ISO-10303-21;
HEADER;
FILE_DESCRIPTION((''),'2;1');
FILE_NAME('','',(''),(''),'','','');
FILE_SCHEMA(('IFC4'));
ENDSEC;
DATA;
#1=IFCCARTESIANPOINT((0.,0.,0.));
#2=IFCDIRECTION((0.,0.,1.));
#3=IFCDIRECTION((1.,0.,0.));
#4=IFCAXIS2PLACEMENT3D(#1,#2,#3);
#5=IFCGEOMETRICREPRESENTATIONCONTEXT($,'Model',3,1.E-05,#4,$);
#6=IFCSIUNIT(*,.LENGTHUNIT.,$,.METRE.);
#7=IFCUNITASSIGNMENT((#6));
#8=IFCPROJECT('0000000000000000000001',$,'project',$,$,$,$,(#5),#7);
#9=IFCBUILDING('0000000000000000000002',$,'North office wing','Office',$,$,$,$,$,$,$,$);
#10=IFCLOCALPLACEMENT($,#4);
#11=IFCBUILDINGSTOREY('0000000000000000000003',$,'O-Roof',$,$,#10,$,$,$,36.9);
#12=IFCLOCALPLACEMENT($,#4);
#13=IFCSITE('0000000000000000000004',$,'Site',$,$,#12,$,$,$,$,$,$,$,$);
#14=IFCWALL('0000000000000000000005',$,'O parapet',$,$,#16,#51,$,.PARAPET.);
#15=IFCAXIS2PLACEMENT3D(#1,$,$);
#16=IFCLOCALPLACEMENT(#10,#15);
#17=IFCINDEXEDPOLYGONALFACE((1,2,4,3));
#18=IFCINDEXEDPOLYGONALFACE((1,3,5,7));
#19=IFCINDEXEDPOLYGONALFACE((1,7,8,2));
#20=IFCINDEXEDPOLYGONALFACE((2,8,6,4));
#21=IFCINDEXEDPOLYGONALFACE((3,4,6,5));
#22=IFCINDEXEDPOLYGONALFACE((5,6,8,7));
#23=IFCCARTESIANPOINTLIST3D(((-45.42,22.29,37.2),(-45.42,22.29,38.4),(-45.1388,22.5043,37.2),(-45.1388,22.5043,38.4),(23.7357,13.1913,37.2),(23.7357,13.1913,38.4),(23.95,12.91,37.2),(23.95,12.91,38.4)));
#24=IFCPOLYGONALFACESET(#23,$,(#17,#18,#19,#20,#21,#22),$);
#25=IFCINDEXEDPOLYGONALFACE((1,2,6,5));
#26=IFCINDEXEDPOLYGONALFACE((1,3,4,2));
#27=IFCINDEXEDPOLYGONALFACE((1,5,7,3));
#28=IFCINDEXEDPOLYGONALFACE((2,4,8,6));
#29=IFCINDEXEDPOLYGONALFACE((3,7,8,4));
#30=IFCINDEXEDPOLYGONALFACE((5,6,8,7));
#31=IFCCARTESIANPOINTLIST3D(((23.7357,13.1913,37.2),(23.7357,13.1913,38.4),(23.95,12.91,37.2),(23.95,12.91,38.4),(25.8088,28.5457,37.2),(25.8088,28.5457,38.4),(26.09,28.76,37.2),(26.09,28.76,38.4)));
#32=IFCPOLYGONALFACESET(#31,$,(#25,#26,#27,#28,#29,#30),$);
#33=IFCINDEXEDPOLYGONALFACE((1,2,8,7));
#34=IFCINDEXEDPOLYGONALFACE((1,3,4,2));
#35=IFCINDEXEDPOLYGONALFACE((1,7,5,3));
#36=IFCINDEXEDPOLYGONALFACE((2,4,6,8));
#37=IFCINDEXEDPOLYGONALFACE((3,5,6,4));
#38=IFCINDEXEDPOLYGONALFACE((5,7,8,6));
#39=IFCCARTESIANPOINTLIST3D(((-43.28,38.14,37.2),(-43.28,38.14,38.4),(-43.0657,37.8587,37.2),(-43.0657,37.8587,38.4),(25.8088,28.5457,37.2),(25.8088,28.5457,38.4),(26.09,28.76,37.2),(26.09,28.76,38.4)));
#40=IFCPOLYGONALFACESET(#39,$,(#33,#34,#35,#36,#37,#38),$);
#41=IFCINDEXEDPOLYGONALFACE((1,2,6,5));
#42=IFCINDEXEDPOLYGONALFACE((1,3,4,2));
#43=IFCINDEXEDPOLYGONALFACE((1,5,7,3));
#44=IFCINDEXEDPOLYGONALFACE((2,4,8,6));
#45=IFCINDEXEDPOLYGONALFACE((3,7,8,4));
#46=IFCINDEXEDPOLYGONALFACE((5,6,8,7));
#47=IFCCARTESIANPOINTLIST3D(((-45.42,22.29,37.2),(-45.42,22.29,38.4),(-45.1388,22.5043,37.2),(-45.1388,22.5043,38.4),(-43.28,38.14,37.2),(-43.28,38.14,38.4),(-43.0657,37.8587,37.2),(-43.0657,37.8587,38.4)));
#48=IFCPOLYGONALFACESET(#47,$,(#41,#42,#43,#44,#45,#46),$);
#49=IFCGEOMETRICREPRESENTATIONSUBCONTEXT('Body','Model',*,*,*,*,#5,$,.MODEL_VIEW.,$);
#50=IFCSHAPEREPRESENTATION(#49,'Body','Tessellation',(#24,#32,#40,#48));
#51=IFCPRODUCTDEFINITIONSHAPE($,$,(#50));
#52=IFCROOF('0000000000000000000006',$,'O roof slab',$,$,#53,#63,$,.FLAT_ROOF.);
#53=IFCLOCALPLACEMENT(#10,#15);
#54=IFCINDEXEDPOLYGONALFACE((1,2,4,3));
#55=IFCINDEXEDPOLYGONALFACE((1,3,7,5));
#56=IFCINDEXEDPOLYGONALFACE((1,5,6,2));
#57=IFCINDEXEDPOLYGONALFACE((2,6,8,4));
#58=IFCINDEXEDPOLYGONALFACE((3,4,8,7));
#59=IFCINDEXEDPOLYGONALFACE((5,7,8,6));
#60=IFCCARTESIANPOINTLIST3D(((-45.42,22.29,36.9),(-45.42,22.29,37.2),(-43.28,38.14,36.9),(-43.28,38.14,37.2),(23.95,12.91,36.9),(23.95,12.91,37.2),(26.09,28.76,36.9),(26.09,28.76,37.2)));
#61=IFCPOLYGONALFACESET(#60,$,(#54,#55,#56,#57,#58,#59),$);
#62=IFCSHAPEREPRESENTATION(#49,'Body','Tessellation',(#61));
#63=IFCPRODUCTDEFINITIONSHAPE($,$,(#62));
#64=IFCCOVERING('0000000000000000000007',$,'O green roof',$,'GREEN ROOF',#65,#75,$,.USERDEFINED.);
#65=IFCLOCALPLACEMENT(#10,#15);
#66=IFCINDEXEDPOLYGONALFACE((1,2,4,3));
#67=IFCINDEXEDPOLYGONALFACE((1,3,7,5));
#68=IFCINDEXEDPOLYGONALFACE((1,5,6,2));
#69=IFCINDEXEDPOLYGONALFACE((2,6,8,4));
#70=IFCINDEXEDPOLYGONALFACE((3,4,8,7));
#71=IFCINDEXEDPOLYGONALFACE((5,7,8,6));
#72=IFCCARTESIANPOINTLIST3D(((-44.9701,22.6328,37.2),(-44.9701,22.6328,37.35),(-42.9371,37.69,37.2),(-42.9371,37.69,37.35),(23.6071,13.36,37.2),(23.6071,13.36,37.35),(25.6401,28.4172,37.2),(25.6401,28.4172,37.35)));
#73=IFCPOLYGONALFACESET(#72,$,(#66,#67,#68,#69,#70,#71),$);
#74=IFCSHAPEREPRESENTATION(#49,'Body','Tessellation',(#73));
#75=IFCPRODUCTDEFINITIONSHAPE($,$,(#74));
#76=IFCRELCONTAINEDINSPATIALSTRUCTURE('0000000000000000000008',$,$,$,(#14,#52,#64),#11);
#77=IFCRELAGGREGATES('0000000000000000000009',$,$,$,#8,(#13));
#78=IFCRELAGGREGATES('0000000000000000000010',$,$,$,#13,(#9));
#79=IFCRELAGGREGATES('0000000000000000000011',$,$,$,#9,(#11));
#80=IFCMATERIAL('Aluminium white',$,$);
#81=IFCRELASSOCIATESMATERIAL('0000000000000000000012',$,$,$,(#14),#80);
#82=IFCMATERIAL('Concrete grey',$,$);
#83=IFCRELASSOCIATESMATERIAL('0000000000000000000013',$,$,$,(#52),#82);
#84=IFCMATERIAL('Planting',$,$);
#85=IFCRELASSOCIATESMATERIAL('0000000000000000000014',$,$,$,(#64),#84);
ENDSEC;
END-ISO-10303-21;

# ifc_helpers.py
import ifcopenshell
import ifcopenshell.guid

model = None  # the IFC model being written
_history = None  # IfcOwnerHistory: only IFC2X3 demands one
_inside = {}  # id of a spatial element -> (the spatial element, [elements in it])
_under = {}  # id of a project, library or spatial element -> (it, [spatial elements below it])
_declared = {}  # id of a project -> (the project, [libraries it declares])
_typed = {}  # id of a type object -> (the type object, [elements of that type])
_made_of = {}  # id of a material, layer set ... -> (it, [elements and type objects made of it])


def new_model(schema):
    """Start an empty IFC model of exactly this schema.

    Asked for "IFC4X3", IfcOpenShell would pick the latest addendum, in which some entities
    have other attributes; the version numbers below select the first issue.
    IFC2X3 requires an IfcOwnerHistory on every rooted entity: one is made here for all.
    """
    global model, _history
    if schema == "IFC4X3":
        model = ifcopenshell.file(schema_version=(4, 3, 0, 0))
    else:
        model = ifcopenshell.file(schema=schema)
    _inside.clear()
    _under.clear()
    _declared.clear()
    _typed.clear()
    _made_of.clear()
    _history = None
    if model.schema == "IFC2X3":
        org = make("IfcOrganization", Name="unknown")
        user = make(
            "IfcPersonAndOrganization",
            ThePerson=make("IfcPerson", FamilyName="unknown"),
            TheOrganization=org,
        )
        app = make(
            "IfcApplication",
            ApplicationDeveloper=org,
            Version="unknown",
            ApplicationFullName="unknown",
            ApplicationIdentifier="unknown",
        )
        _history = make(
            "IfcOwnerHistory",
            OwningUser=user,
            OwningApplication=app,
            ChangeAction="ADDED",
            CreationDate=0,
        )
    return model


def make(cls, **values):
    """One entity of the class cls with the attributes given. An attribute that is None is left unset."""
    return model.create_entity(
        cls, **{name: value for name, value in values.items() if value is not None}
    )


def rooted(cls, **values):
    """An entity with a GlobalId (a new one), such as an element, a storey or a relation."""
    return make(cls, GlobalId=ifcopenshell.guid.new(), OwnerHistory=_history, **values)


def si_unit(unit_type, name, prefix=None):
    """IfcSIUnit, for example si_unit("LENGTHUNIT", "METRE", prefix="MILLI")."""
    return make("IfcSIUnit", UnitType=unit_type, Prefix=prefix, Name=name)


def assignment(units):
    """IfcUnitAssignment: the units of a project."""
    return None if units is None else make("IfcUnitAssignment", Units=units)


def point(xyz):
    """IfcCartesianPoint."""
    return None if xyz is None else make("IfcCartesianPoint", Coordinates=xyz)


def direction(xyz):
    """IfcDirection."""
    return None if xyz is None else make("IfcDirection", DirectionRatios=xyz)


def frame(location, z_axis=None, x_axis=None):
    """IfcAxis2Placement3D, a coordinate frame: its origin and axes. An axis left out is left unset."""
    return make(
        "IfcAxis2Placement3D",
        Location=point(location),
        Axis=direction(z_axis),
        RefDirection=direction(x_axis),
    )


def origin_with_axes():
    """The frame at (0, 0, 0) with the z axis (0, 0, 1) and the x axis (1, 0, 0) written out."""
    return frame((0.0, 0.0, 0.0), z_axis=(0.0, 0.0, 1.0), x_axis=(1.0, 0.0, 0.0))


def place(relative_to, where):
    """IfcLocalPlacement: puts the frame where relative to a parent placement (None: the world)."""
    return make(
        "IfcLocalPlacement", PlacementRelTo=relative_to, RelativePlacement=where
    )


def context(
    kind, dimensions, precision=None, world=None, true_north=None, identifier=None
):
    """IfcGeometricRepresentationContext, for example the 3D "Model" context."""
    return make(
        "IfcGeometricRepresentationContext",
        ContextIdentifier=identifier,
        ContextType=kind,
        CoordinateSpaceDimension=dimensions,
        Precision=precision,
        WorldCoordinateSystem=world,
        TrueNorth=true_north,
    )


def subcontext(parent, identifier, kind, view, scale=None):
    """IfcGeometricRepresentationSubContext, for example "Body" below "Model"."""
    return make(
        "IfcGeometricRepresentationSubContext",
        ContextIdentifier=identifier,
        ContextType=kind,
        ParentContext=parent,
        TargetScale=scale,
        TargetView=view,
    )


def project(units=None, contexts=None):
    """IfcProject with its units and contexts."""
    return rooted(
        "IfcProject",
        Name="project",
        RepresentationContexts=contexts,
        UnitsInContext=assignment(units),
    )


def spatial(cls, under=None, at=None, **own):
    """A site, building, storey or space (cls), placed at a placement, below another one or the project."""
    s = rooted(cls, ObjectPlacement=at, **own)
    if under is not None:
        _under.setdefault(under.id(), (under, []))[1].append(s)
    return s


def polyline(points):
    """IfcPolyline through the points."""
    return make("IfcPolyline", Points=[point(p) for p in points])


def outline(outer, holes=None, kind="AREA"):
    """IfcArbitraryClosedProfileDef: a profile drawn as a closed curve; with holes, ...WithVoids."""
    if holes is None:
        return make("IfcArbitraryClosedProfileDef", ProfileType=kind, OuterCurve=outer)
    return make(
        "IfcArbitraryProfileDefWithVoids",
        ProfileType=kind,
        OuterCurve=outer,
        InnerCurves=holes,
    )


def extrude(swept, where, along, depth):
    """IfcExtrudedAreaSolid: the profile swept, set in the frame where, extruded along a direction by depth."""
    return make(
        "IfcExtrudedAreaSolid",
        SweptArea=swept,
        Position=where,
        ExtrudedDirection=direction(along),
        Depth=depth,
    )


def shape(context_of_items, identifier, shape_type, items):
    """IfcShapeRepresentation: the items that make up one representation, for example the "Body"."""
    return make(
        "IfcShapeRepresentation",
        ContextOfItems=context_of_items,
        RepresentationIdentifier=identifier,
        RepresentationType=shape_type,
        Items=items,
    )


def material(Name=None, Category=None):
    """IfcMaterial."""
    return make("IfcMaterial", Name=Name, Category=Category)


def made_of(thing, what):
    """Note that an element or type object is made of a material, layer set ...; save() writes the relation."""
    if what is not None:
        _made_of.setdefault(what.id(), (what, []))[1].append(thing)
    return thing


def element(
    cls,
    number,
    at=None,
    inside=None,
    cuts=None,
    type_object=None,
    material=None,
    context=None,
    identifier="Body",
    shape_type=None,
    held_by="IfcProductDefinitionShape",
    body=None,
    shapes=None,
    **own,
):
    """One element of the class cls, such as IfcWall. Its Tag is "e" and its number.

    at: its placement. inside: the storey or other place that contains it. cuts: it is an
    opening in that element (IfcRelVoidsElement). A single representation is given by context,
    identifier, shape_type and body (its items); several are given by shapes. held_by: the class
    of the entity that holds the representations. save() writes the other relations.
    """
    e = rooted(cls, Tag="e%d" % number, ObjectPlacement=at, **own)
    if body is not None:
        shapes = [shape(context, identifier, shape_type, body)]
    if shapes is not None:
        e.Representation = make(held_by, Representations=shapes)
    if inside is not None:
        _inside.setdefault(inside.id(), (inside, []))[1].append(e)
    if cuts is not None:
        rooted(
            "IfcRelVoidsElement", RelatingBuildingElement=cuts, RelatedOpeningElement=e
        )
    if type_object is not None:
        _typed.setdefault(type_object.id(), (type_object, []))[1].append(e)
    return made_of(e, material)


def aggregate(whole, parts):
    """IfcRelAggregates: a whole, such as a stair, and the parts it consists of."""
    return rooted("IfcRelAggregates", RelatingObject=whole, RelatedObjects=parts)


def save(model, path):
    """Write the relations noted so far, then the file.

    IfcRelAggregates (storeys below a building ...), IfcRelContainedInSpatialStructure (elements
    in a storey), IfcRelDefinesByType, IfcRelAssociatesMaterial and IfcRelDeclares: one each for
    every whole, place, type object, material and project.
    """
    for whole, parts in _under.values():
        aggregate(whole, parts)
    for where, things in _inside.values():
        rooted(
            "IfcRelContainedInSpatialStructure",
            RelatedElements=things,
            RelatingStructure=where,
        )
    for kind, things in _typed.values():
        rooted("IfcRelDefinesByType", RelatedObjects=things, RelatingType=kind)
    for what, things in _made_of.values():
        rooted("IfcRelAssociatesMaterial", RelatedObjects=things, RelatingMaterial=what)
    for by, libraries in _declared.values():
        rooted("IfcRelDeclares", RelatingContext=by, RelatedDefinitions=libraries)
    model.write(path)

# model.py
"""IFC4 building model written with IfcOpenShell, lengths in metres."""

from ifc_helpers import new_model, si_unit, frame, origin_with_axes, place, context, subcontext, project, spatial, polyline, outline, extrude, material, element, save


model = new_model("IFC4")

# Units and contexts
model_context = context("Model", 3, precision=1e-05, world=origin_with_axes())
body_context = subcontext(model_context, "Body", "Model", "MODEL_VIEW")
ifc_project = project(units=[si_unit("LENGTHUNIT", "METRE")], contexts=[model_context])

# Site, building, storey
site_placement = place(None, origin_with_axes())
site = spatial("IfcSite", under=ifc_project, at=site_placement, Name="Site")
building = spatial("IfcBuilding", under=site, Name="North office wing", Description="Office")
storey_placement = place(None, origin_with_axes())
storey = spatial("IfcBuildingStorey", under=building, at=storey_placement, Name="O-Roof", Elevation=36.9)

# Wall
ifc_material_1 = material(Name="Aluminium white")
wall_placement = place(storey_placement, origin_with_axes())
element("IfcWall", 1, at=wall_placement, inside=storey, material=ifc_material_1, Name="O parapet", PredefinedType="PARAPET", context=body_context, shape_type="SweptSolid", body=[
    extrude(outline(polyline([(-45.42, 22.29), (23.95, 12.91), (23.7357, 13.1913), (-45.1388, 22.5043), (-45.42, 22.29)])), frame((0.0, 0.0, 37.2), z_axis=(0.0, 0.0, 1.0), x_axis=(1.0, 0.0, 0.0)), (0.0, 0.0, 1.0), 1.2),
    extrude(outline(polyline([(23.95, 12.91), (26.09, 28.76), (25.8088, 28.5457), (23.7357, 13.1913), (23.95, 12.91)])), frame((0.0, 0.0, 37.2), z_axis=(0.0, 0.0, 1.0), x_axis=(1.0, 0.0, 0.0)), (0.0, 0.0, 1.0), 1.2),
    extrude(outline(polyline([(26.09, 28.76), (-43.28, 38.14), (-43.0657, 37.8587), (25.8088, 28.5457), (26.09, 28.76)])), frame((0.0, 0.0, 37.2), z_axis=(0.0, 0.0, 1.0), x_axis=(1.0, 0.0, 0.0)), (0.0, 0.0, 1.0), 1.2),
    extrude(outline(polyline([(-43.28, 38.14), (-45.42, 22.29), (-45.1388, 22.5043), (-43.0657, 37.8587), (-43.28, 38.14)])), frame((0.0, 0.0, 37.2), z_axis=(0.0, 0.0, 1.0), x_axis=(1.0, 0.0, 0.0)), (0.0, 0.0, 1.0), 1.2),
])

# Roof
ifc_material_2 = material(Name="Concrete grey")
roof_placement = place(storey_placement, origin_with_axes())
element("IfcRoof", 2, at=roof_placement, inside=storey, material=ifc_material_2, Name="O roof slab", PredefinedType="FLAT_ROOF", context=body_context, shape_type="SweptSolid", body=[
    extrude(outline(polyline([(-45.42, 22.29), (23.95, 12.91), (26.09, 28.76), (-43.28, 38.14), (-45.42, 22.29)])), frame((0.0, 0.0, 36.9), z_axis=(0.0, 0.0, 1.0), x_axis=(1.0, 0.0, 0.0)), (0.0, 0.0, 1.0), 0.3),
])

# Covering
ifc_material_3 = material(Name="Planting")
covering_placement = place(storey_placement, origin_with_axes())
element("IfcCovering", 3, at=covering_placement, inside=storey, material=ifc_material_3, Name="O green roof", ObjectType="GREEN ROOF", PredefinedType="USERDEFINED", context=body_context, shape_type="SweptSolid", body=[
    extrude(outline(polyline([(-44.9701, 22.6328), (23.6071, 13.36), (25.6401, 28.4172), (-42.9371, 37.69), (-44.9701, 22.6328)])), frame((0.0, 0.0, 37.2), z_axis=(0.0, 0.0, 1.0), x_axis=(1.0, 0.0, 0.0)), (0.0, 0.0, 1.0), 0.15),
])

save(model, "model.ifc")
